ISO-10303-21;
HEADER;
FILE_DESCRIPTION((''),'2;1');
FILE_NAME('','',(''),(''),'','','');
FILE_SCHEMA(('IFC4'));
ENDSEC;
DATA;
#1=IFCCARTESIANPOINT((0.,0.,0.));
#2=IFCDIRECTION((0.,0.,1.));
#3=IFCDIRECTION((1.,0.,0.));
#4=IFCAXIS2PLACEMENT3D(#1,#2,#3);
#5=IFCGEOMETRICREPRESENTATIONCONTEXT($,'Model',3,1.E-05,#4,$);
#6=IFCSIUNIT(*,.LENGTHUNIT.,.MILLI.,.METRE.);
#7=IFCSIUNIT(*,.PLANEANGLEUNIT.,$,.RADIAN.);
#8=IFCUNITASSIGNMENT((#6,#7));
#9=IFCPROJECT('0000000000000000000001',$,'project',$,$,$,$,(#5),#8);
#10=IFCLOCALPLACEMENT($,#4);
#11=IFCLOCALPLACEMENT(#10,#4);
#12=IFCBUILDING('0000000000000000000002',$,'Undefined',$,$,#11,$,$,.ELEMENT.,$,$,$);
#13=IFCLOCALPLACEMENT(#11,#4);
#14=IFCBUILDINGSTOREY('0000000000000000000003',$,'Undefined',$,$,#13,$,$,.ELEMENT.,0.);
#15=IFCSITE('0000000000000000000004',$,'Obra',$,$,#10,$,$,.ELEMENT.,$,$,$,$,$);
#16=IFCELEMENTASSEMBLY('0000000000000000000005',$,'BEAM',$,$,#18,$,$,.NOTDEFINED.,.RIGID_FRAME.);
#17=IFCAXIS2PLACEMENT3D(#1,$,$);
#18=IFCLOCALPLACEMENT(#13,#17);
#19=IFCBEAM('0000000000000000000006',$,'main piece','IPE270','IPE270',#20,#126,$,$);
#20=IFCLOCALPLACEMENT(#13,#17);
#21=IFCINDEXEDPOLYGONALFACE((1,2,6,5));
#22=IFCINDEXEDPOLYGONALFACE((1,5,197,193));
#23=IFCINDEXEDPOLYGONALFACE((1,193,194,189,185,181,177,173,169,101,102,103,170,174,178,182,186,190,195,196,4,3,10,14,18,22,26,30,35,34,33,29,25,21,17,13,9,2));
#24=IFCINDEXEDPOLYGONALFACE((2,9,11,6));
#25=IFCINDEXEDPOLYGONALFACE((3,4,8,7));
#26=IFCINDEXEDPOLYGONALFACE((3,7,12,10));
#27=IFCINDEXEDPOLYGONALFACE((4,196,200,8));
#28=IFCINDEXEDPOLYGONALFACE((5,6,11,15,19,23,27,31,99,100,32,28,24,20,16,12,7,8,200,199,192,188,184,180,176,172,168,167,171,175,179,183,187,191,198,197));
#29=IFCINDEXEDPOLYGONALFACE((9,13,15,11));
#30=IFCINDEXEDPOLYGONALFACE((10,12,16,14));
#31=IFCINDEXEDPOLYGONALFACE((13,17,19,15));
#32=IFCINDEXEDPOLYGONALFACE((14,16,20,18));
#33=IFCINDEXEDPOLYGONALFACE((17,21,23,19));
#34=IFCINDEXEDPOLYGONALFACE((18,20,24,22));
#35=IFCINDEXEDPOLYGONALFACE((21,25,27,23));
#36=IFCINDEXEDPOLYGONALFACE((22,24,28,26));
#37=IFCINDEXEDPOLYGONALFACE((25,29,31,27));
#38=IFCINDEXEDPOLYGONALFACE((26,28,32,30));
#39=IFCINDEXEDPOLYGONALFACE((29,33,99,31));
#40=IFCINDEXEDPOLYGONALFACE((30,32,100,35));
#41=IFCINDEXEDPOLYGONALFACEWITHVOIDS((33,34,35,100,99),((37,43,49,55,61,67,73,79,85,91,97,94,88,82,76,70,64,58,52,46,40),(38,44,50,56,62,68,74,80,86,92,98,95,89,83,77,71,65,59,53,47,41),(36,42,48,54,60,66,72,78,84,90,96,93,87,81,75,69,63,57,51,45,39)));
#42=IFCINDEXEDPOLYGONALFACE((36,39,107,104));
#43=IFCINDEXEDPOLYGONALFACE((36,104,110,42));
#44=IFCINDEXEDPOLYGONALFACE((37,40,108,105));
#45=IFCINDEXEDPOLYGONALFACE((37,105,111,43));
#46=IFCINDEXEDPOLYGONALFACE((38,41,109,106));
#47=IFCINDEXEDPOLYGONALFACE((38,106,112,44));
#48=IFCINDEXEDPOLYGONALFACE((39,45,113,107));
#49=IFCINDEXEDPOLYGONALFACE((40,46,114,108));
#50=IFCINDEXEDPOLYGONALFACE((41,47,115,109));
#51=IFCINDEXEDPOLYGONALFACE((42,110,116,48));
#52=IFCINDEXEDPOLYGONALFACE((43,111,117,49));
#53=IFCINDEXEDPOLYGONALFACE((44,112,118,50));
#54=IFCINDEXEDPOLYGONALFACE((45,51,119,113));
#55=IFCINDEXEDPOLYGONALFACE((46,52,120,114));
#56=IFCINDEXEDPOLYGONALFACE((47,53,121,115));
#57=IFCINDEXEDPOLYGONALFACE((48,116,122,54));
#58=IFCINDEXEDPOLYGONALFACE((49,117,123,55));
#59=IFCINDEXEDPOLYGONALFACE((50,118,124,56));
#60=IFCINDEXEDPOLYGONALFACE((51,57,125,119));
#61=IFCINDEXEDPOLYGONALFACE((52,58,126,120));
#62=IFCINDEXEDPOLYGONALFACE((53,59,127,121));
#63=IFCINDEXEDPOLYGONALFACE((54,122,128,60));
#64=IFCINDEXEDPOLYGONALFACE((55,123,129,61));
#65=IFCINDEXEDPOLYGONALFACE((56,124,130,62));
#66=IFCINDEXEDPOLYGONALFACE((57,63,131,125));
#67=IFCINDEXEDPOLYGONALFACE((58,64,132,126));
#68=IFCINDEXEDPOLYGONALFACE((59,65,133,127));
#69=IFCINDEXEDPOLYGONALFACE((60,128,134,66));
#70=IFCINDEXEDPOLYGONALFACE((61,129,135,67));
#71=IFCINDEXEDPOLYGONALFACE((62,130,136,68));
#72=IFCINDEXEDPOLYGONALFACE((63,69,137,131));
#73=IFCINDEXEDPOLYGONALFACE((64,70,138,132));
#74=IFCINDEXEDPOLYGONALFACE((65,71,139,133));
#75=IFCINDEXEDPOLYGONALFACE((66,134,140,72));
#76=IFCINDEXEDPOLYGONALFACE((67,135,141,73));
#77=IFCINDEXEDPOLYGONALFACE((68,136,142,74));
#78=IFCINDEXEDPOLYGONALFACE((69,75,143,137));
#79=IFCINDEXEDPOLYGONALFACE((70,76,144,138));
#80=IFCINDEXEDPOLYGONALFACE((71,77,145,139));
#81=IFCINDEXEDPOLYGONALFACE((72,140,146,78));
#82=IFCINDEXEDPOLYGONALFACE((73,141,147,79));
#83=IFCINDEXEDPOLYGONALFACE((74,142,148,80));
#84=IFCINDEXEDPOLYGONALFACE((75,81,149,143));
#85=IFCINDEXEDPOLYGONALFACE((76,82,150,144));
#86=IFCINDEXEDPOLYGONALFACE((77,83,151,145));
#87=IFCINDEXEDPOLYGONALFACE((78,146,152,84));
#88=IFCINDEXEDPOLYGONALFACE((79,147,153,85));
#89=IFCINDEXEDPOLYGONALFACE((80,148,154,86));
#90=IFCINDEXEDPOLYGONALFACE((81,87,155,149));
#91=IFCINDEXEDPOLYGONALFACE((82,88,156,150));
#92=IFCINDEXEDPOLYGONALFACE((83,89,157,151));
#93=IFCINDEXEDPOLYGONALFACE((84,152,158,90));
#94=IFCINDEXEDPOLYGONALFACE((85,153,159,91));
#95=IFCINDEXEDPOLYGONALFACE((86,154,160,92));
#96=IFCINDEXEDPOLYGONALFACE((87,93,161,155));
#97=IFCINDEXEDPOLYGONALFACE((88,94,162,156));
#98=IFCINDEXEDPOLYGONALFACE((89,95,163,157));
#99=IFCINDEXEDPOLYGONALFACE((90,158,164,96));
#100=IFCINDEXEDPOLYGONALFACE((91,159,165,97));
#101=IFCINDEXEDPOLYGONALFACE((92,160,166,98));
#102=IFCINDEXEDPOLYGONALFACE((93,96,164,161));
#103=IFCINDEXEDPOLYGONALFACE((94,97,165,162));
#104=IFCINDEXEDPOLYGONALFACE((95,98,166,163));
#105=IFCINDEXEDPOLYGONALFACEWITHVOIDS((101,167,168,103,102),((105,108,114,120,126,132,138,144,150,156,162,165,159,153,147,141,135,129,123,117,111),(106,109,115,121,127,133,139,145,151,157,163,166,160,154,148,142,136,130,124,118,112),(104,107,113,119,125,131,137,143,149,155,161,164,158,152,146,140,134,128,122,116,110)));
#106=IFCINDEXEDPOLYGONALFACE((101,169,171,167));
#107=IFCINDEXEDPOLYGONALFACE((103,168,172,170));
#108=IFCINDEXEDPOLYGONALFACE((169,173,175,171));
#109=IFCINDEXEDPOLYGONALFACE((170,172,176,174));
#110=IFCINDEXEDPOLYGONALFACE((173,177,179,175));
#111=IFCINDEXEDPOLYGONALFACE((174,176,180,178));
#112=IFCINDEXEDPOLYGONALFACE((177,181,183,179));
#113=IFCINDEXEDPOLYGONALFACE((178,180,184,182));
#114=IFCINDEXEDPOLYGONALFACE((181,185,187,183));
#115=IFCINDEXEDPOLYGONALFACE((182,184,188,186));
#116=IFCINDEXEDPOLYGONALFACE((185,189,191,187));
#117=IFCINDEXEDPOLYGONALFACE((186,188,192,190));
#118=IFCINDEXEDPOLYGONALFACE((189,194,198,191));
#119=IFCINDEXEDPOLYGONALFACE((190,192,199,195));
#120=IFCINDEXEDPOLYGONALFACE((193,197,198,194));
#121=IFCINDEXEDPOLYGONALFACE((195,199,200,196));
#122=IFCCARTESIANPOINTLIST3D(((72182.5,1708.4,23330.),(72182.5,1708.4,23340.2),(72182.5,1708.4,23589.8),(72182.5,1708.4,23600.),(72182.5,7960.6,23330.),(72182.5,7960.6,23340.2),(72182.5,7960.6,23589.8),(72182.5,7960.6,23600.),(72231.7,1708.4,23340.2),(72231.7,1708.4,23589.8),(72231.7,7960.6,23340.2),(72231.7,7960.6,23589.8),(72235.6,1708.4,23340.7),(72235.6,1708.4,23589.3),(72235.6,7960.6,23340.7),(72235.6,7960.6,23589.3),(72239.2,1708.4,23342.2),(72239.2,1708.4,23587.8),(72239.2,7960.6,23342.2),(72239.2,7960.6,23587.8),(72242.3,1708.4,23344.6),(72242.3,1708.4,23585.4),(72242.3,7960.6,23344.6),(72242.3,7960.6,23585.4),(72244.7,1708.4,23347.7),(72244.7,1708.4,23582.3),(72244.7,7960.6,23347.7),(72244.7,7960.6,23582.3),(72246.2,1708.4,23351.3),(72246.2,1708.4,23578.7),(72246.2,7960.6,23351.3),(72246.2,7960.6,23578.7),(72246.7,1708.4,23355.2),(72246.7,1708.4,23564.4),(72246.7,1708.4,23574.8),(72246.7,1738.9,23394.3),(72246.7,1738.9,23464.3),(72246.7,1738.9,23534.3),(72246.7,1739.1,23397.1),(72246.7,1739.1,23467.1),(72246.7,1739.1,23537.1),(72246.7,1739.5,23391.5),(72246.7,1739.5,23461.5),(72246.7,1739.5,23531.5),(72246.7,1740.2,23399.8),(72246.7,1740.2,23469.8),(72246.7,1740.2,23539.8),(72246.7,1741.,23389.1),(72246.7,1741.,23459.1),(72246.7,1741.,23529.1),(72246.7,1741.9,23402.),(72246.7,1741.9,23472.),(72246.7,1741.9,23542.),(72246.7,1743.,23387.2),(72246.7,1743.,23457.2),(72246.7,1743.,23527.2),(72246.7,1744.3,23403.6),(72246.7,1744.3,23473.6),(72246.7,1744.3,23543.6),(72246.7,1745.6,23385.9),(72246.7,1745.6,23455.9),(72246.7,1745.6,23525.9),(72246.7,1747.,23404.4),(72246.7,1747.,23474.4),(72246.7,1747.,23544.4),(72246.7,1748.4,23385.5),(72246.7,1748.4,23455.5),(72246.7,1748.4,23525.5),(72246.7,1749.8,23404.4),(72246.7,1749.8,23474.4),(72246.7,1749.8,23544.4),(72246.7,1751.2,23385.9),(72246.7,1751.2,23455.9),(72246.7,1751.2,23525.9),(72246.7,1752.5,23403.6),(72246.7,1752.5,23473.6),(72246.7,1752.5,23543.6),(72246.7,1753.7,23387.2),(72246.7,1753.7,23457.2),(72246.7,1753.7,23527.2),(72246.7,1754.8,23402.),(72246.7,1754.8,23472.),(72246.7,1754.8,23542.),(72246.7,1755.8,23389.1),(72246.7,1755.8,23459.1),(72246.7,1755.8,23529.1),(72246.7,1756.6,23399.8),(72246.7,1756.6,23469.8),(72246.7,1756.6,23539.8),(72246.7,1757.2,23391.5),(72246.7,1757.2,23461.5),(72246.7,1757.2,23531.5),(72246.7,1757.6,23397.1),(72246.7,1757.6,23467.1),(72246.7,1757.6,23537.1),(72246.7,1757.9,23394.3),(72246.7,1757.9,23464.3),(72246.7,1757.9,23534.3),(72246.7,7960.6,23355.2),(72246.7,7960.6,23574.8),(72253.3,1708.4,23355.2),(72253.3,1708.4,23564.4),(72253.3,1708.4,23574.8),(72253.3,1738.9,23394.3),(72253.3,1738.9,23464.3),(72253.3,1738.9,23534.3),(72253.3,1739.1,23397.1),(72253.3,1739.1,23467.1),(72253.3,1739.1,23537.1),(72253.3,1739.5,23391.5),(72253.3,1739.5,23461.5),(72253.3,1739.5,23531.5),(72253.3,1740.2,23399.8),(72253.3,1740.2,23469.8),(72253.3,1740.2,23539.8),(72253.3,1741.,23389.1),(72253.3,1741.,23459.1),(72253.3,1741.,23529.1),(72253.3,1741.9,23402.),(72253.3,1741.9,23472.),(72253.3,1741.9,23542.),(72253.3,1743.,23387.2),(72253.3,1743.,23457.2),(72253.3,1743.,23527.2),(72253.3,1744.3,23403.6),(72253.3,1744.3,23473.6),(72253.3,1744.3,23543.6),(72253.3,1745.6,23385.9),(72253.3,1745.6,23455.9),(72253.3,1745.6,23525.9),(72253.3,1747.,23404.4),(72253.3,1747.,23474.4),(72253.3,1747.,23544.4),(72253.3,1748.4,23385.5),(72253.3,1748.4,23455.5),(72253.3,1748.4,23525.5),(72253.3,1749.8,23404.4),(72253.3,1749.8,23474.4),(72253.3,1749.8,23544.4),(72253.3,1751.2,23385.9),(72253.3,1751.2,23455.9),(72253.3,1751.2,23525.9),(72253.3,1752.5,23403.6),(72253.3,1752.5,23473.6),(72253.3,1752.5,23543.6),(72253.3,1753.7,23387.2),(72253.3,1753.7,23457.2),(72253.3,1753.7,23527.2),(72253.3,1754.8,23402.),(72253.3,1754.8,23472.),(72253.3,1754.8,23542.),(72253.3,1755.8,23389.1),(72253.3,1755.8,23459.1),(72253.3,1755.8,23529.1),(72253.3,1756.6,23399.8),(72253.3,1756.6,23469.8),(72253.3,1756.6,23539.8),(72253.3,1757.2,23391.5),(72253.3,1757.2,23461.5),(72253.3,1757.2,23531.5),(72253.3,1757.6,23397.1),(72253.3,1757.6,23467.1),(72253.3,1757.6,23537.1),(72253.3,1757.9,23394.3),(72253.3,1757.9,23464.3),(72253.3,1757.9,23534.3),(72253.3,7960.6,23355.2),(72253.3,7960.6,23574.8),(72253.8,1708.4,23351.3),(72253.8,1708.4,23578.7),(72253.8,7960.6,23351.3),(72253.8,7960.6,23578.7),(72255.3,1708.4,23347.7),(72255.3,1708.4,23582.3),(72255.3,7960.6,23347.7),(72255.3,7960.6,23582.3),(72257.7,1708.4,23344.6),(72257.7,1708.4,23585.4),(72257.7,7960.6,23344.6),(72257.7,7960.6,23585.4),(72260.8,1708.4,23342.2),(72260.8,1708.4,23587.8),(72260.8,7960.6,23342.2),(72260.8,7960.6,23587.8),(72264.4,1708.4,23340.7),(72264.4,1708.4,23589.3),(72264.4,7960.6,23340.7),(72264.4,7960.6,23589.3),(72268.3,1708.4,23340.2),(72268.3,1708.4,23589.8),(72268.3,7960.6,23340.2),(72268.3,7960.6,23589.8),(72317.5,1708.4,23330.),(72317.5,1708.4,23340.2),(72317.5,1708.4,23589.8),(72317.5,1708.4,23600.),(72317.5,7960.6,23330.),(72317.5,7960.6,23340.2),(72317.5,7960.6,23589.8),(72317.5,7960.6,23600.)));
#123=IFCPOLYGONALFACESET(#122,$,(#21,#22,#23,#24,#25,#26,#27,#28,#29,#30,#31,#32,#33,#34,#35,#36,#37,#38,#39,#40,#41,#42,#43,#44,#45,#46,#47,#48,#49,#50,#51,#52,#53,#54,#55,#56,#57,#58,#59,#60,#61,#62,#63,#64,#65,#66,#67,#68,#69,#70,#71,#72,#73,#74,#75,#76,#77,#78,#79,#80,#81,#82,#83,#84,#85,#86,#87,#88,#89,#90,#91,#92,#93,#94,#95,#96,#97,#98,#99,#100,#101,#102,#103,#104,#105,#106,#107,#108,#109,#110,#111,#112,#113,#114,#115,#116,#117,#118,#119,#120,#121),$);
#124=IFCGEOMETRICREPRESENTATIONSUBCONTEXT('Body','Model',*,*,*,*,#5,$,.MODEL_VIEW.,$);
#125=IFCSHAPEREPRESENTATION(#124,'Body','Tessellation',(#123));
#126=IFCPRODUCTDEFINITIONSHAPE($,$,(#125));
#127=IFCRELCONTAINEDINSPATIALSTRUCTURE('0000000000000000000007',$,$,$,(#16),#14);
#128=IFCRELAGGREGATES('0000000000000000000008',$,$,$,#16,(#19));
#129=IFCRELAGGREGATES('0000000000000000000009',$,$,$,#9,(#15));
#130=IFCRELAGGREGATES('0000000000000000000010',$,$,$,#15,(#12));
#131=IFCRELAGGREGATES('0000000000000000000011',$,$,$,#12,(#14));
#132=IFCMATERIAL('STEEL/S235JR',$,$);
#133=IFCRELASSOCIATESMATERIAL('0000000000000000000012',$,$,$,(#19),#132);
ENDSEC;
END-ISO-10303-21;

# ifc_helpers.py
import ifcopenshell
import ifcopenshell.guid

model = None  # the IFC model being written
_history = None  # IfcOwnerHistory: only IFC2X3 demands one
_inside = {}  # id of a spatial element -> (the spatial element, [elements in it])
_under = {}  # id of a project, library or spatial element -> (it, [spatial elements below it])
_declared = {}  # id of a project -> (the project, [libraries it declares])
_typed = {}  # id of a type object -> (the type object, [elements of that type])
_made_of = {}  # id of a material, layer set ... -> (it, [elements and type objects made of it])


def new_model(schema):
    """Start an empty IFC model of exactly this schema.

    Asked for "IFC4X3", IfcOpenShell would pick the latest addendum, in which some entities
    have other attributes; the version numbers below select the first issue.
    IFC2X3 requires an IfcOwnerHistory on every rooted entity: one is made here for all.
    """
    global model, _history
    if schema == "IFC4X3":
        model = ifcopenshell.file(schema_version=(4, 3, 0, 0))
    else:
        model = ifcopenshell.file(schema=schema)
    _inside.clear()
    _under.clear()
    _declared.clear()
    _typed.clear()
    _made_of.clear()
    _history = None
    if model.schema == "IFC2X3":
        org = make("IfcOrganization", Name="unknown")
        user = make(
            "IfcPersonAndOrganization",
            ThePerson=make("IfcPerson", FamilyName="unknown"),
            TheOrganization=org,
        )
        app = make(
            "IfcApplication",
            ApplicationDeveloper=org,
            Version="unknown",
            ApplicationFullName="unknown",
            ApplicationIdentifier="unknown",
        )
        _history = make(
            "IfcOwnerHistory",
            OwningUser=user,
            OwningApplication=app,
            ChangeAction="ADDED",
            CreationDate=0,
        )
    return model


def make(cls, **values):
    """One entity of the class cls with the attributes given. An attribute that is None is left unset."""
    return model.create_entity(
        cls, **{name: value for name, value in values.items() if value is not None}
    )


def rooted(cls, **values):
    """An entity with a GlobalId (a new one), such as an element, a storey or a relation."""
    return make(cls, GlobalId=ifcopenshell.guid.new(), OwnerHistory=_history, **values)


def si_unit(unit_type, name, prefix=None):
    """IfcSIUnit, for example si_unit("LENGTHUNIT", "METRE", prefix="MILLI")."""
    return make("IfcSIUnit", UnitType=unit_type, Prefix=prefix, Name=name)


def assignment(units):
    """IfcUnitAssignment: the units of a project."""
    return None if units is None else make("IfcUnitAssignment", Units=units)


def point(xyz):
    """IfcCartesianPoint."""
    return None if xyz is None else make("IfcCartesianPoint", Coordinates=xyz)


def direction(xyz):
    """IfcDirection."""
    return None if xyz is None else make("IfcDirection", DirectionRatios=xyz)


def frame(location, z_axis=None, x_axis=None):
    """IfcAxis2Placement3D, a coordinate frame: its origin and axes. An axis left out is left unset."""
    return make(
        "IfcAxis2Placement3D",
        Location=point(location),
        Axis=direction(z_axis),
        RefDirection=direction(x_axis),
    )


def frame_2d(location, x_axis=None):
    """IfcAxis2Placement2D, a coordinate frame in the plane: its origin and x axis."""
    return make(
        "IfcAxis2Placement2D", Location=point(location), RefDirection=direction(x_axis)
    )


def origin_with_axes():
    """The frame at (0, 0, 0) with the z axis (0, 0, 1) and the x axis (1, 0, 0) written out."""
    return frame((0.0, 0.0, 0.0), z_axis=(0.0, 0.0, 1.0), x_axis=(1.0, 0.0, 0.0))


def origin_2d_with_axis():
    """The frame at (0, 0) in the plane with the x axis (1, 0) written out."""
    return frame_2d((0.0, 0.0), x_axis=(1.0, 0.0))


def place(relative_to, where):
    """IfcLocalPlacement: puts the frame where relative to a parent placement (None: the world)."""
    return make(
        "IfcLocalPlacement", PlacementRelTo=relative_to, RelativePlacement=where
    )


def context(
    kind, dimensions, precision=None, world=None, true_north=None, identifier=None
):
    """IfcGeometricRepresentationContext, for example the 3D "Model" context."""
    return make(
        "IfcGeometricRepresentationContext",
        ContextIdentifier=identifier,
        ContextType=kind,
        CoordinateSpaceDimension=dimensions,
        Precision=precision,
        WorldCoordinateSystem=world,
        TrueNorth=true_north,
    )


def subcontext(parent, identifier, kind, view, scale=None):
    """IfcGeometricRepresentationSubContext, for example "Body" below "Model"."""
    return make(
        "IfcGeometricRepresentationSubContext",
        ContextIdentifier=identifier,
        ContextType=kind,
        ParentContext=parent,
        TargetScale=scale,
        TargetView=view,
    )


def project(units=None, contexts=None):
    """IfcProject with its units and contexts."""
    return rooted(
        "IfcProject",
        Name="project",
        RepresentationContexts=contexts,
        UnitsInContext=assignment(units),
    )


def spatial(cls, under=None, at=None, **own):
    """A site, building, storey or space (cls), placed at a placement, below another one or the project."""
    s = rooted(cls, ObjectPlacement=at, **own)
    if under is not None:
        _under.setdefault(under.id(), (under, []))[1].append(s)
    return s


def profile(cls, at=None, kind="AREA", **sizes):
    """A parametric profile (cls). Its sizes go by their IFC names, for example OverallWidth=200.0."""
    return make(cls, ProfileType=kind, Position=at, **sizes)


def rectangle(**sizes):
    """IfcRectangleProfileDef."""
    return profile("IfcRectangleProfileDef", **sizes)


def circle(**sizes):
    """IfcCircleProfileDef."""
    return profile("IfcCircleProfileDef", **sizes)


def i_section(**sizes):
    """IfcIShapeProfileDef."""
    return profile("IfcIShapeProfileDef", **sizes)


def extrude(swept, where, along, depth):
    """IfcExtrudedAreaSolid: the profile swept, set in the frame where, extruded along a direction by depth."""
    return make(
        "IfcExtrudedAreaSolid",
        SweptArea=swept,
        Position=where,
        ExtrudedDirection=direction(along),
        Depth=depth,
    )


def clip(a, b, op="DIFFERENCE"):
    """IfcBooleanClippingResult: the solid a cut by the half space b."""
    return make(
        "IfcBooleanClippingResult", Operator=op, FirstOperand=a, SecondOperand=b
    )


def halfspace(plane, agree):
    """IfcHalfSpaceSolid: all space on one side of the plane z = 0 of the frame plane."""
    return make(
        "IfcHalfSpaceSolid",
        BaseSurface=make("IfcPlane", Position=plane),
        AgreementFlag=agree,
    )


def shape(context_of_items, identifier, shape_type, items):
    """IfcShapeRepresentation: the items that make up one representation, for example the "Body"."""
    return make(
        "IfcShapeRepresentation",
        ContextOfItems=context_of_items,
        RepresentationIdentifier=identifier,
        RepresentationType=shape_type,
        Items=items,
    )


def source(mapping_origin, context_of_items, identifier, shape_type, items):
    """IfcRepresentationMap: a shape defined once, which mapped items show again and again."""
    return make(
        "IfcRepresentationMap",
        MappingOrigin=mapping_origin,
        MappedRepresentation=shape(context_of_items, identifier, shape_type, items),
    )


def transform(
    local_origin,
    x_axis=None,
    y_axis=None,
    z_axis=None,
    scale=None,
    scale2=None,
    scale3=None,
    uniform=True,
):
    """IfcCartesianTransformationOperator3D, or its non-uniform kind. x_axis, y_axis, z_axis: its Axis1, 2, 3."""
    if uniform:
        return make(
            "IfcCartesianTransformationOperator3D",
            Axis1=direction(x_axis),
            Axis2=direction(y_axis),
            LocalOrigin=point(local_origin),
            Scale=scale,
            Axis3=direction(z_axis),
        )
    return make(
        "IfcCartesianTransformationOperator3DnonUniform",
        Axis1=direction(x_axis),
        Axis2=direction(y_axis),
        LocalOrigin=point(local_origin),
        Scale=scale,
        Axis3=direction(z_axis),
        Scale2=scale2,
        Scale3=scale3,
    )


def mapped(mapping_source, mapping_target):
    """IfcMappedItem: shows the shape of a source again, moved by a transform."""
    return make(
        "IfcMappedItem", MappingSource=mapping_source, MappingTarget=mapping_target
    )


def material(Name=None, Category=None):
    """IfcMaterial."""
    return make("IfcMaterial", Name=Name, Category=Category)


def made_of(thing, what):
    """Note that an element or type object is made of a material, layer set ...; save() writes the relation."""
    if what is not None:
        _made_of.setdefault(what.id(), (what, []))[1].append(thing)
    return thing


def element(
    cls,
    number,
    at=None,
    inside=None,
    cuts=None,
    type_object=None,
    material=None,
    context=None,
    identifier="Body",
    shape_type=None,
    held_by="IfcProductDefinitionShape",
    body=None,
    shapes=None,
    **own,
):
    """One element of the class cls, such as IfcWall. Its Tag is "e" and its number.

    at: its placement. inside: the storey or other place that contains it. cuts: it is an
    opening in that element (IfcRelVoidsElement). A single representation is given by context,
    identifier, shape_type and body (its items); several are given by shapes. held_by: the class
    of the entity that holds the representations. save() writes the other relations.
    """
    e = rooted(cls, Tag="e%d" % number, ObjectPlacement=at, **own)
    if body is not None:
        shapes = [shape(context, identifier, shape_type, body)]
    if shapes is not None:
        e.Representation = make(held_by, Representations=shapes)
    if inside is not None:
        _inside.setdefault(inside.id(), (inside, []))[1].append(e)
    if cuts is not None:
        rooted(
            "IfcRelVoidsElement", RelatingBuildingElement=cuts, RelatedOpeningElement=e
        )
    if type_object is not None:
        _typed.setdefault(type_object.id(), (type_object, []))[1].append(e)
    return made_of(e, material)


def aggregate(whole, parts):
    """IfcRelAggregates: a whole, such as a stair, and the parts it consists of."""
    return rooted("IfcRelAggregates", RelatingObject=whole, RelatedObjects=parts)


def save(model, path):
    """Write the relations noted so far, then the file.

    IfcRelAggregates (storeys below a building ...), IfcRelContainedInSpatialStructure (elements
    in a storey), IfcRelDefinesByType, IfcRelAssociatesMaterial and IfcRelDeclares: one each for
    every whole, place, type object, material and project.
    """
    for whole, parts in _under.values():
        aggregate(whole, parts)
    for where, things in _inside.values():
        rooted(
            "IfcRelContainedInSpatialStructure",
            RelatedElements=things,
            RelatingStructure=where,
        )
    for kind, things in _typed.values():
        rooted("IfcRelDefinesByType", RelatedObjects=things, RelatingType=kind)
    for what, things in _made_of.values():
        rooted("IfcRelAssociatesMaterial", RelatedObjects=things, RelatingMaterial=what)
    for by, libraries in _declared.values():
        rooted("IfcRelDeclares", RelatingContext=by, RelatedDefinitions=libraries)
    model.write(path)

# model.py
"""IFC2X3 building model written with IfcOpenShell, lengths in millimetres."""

from ifc_helpers import new_model, si_unit, frame, origin_with_axes, origin_2d_with_axis, place, context, subcontext, project, spatial, rectangle, circle, i_section, extrude, clip, halfspace, source, transform, mapped, material, element, aggregate, save


model = new_model("IFC2X3")

# Units and contexts
model_context = context("Model", 3, precision=1e-05, world=origin_with_axes())
body_context = subcontext(model_context, "Body", "Model", "MODEL_VIEW")
ifc_project = project(units=[si_unit("LENGTHUNIT", "METRE", prefix="MILLI"), si_unit("PLANEANGLEUNIT", "RADIAN")], contexts=[model_context])

# Site, building, storey
site_placement = place(None, origin_with_axes())
site = spatial("IfcSite", under=ifc_project, at=site_placement, Name="Obra", CompositionType="ELEMENT")
building_placement = place(site_placement, origin_with_axes())
building = spatial("IfcBuilding", under=site, at=building_placement, Name="Undefined", CompositionType="ELEMENT")
storey_placement = place(building_placement, origin_with_axes())
storey = spatial("IfcBuildingStorey", under=building, at=storey_placement, Name="Undefined", CompositionType="ELEMENT", Elevation=0.0)

# Element assembly, beam, openings
assembly_1_placement = place(storey_placement, origin_with_axes())
assembly_1 = element("IfcElementAssembly", 1, at=assembly_1_placement, inside=storey, Name="BEAM", AssemblyPlace="NOTDEFINED", PredefinedType="RIGID_FRAME")
ifc_material_1 = material(Name="STEEL/S235JR")
beam_1_placement = place(assembly_1_placement, frame((72250.0, 1711.1, 23465.0), z_axis=(0.0, 0.0, 1.0), x_axis=(0.0, 1.0, 0.0)))
beam_1 = element("IfcBeam", 2, at=beam_1_placement, material=ifc_material_1, Name="main piece", Description="IPE270", ObjectType="IPE270", context=body_context, shape_type="Clipping", body=[
    clip(clip(extrude(i_section(OverallWidth=135.0, OverallDepth=270.0, WebThickness=6.6, FlangeThickness=10.2, FilletRadius=15.0, at=origin_2d_with_axis()), frame((6296.4, 0.0, 0.0), z_axis=(-1.0, 0.0, 0.0), x_axis=(0.0, -1.0, 0.0)), (0.0, 0.0, 1.0), 6299.1), halfspace(frame((6249.5, -60.0, -120.0), z_axis=(1.0, 0.0, 0.0), x_axis=(0.0, 0.0, 1.0)), False)), halfspace(frame((-2.7, 0.0, -235.0), z_axis=(1.0, 0.0, 0.0), x_axis=(0.0, -1.0, 0.0)), True)),
])
opening_1_placement = place(assembly_1_placement, frame((72250.0, 1711.1, 23465.0), z_axis=(0.0, 0.0, 1.0), x_axis=(0.0, 1.0, 0.0)))
element("IfcOpeningElement", 3, at=opening_1_placement, cuts=beam_1, ObjectType="Recess", context=body_context, shape_type="SweptSolid", body=[
    extrude(rectangle(XDim=36.6, YDim=102.3, at=origin_2d_with_axis()), frame((-53.9, -68.5, 117.7), z_axis=(0.0, 1.0, 0.0), x_axis=(0.0, 0.0, -1.0)), (0.0, 0.0, 1.0), 137.0),
])
shared_shape_1 = source(origin_with_axes(), body_context, "Body", "SweptSolid", [
    extrude(circle(Radius=9.5, at=origin_2d_with_axis()), frame((0.0, -3.4, 0.0), z_axis=(0.0, 1.0, 0.0), x_axis=(1.0, 0.0, 0.0)), (0.0, 0.0, 1.0), 6.8),
])
opening_2_placement = place(assembly_1_placement, frame((72250.0, 1708.4, 23570.0), z_axis=(0.0, 1.0, 0.0), x_axis=(0.0, 0.0, -1.0)))
element("IfcOpeningElement", 4, at=opening_2_placement, cuts=beam_1, ObjectType="Opening", context=body_context, shape_type="MappedRepresentation", body=[
    mapped(shared_shape_1, transform((35.0, 0.0, 40.0))),
    mapped(shared_shape_1, transform((105.0, 0.0, 40.0))),
    mapped(shared_shape_1, transform((175.0, 0.0, 40.0))),
])

aggregate(assembly_1, [beam_1])

save(model, "model.ifc")
